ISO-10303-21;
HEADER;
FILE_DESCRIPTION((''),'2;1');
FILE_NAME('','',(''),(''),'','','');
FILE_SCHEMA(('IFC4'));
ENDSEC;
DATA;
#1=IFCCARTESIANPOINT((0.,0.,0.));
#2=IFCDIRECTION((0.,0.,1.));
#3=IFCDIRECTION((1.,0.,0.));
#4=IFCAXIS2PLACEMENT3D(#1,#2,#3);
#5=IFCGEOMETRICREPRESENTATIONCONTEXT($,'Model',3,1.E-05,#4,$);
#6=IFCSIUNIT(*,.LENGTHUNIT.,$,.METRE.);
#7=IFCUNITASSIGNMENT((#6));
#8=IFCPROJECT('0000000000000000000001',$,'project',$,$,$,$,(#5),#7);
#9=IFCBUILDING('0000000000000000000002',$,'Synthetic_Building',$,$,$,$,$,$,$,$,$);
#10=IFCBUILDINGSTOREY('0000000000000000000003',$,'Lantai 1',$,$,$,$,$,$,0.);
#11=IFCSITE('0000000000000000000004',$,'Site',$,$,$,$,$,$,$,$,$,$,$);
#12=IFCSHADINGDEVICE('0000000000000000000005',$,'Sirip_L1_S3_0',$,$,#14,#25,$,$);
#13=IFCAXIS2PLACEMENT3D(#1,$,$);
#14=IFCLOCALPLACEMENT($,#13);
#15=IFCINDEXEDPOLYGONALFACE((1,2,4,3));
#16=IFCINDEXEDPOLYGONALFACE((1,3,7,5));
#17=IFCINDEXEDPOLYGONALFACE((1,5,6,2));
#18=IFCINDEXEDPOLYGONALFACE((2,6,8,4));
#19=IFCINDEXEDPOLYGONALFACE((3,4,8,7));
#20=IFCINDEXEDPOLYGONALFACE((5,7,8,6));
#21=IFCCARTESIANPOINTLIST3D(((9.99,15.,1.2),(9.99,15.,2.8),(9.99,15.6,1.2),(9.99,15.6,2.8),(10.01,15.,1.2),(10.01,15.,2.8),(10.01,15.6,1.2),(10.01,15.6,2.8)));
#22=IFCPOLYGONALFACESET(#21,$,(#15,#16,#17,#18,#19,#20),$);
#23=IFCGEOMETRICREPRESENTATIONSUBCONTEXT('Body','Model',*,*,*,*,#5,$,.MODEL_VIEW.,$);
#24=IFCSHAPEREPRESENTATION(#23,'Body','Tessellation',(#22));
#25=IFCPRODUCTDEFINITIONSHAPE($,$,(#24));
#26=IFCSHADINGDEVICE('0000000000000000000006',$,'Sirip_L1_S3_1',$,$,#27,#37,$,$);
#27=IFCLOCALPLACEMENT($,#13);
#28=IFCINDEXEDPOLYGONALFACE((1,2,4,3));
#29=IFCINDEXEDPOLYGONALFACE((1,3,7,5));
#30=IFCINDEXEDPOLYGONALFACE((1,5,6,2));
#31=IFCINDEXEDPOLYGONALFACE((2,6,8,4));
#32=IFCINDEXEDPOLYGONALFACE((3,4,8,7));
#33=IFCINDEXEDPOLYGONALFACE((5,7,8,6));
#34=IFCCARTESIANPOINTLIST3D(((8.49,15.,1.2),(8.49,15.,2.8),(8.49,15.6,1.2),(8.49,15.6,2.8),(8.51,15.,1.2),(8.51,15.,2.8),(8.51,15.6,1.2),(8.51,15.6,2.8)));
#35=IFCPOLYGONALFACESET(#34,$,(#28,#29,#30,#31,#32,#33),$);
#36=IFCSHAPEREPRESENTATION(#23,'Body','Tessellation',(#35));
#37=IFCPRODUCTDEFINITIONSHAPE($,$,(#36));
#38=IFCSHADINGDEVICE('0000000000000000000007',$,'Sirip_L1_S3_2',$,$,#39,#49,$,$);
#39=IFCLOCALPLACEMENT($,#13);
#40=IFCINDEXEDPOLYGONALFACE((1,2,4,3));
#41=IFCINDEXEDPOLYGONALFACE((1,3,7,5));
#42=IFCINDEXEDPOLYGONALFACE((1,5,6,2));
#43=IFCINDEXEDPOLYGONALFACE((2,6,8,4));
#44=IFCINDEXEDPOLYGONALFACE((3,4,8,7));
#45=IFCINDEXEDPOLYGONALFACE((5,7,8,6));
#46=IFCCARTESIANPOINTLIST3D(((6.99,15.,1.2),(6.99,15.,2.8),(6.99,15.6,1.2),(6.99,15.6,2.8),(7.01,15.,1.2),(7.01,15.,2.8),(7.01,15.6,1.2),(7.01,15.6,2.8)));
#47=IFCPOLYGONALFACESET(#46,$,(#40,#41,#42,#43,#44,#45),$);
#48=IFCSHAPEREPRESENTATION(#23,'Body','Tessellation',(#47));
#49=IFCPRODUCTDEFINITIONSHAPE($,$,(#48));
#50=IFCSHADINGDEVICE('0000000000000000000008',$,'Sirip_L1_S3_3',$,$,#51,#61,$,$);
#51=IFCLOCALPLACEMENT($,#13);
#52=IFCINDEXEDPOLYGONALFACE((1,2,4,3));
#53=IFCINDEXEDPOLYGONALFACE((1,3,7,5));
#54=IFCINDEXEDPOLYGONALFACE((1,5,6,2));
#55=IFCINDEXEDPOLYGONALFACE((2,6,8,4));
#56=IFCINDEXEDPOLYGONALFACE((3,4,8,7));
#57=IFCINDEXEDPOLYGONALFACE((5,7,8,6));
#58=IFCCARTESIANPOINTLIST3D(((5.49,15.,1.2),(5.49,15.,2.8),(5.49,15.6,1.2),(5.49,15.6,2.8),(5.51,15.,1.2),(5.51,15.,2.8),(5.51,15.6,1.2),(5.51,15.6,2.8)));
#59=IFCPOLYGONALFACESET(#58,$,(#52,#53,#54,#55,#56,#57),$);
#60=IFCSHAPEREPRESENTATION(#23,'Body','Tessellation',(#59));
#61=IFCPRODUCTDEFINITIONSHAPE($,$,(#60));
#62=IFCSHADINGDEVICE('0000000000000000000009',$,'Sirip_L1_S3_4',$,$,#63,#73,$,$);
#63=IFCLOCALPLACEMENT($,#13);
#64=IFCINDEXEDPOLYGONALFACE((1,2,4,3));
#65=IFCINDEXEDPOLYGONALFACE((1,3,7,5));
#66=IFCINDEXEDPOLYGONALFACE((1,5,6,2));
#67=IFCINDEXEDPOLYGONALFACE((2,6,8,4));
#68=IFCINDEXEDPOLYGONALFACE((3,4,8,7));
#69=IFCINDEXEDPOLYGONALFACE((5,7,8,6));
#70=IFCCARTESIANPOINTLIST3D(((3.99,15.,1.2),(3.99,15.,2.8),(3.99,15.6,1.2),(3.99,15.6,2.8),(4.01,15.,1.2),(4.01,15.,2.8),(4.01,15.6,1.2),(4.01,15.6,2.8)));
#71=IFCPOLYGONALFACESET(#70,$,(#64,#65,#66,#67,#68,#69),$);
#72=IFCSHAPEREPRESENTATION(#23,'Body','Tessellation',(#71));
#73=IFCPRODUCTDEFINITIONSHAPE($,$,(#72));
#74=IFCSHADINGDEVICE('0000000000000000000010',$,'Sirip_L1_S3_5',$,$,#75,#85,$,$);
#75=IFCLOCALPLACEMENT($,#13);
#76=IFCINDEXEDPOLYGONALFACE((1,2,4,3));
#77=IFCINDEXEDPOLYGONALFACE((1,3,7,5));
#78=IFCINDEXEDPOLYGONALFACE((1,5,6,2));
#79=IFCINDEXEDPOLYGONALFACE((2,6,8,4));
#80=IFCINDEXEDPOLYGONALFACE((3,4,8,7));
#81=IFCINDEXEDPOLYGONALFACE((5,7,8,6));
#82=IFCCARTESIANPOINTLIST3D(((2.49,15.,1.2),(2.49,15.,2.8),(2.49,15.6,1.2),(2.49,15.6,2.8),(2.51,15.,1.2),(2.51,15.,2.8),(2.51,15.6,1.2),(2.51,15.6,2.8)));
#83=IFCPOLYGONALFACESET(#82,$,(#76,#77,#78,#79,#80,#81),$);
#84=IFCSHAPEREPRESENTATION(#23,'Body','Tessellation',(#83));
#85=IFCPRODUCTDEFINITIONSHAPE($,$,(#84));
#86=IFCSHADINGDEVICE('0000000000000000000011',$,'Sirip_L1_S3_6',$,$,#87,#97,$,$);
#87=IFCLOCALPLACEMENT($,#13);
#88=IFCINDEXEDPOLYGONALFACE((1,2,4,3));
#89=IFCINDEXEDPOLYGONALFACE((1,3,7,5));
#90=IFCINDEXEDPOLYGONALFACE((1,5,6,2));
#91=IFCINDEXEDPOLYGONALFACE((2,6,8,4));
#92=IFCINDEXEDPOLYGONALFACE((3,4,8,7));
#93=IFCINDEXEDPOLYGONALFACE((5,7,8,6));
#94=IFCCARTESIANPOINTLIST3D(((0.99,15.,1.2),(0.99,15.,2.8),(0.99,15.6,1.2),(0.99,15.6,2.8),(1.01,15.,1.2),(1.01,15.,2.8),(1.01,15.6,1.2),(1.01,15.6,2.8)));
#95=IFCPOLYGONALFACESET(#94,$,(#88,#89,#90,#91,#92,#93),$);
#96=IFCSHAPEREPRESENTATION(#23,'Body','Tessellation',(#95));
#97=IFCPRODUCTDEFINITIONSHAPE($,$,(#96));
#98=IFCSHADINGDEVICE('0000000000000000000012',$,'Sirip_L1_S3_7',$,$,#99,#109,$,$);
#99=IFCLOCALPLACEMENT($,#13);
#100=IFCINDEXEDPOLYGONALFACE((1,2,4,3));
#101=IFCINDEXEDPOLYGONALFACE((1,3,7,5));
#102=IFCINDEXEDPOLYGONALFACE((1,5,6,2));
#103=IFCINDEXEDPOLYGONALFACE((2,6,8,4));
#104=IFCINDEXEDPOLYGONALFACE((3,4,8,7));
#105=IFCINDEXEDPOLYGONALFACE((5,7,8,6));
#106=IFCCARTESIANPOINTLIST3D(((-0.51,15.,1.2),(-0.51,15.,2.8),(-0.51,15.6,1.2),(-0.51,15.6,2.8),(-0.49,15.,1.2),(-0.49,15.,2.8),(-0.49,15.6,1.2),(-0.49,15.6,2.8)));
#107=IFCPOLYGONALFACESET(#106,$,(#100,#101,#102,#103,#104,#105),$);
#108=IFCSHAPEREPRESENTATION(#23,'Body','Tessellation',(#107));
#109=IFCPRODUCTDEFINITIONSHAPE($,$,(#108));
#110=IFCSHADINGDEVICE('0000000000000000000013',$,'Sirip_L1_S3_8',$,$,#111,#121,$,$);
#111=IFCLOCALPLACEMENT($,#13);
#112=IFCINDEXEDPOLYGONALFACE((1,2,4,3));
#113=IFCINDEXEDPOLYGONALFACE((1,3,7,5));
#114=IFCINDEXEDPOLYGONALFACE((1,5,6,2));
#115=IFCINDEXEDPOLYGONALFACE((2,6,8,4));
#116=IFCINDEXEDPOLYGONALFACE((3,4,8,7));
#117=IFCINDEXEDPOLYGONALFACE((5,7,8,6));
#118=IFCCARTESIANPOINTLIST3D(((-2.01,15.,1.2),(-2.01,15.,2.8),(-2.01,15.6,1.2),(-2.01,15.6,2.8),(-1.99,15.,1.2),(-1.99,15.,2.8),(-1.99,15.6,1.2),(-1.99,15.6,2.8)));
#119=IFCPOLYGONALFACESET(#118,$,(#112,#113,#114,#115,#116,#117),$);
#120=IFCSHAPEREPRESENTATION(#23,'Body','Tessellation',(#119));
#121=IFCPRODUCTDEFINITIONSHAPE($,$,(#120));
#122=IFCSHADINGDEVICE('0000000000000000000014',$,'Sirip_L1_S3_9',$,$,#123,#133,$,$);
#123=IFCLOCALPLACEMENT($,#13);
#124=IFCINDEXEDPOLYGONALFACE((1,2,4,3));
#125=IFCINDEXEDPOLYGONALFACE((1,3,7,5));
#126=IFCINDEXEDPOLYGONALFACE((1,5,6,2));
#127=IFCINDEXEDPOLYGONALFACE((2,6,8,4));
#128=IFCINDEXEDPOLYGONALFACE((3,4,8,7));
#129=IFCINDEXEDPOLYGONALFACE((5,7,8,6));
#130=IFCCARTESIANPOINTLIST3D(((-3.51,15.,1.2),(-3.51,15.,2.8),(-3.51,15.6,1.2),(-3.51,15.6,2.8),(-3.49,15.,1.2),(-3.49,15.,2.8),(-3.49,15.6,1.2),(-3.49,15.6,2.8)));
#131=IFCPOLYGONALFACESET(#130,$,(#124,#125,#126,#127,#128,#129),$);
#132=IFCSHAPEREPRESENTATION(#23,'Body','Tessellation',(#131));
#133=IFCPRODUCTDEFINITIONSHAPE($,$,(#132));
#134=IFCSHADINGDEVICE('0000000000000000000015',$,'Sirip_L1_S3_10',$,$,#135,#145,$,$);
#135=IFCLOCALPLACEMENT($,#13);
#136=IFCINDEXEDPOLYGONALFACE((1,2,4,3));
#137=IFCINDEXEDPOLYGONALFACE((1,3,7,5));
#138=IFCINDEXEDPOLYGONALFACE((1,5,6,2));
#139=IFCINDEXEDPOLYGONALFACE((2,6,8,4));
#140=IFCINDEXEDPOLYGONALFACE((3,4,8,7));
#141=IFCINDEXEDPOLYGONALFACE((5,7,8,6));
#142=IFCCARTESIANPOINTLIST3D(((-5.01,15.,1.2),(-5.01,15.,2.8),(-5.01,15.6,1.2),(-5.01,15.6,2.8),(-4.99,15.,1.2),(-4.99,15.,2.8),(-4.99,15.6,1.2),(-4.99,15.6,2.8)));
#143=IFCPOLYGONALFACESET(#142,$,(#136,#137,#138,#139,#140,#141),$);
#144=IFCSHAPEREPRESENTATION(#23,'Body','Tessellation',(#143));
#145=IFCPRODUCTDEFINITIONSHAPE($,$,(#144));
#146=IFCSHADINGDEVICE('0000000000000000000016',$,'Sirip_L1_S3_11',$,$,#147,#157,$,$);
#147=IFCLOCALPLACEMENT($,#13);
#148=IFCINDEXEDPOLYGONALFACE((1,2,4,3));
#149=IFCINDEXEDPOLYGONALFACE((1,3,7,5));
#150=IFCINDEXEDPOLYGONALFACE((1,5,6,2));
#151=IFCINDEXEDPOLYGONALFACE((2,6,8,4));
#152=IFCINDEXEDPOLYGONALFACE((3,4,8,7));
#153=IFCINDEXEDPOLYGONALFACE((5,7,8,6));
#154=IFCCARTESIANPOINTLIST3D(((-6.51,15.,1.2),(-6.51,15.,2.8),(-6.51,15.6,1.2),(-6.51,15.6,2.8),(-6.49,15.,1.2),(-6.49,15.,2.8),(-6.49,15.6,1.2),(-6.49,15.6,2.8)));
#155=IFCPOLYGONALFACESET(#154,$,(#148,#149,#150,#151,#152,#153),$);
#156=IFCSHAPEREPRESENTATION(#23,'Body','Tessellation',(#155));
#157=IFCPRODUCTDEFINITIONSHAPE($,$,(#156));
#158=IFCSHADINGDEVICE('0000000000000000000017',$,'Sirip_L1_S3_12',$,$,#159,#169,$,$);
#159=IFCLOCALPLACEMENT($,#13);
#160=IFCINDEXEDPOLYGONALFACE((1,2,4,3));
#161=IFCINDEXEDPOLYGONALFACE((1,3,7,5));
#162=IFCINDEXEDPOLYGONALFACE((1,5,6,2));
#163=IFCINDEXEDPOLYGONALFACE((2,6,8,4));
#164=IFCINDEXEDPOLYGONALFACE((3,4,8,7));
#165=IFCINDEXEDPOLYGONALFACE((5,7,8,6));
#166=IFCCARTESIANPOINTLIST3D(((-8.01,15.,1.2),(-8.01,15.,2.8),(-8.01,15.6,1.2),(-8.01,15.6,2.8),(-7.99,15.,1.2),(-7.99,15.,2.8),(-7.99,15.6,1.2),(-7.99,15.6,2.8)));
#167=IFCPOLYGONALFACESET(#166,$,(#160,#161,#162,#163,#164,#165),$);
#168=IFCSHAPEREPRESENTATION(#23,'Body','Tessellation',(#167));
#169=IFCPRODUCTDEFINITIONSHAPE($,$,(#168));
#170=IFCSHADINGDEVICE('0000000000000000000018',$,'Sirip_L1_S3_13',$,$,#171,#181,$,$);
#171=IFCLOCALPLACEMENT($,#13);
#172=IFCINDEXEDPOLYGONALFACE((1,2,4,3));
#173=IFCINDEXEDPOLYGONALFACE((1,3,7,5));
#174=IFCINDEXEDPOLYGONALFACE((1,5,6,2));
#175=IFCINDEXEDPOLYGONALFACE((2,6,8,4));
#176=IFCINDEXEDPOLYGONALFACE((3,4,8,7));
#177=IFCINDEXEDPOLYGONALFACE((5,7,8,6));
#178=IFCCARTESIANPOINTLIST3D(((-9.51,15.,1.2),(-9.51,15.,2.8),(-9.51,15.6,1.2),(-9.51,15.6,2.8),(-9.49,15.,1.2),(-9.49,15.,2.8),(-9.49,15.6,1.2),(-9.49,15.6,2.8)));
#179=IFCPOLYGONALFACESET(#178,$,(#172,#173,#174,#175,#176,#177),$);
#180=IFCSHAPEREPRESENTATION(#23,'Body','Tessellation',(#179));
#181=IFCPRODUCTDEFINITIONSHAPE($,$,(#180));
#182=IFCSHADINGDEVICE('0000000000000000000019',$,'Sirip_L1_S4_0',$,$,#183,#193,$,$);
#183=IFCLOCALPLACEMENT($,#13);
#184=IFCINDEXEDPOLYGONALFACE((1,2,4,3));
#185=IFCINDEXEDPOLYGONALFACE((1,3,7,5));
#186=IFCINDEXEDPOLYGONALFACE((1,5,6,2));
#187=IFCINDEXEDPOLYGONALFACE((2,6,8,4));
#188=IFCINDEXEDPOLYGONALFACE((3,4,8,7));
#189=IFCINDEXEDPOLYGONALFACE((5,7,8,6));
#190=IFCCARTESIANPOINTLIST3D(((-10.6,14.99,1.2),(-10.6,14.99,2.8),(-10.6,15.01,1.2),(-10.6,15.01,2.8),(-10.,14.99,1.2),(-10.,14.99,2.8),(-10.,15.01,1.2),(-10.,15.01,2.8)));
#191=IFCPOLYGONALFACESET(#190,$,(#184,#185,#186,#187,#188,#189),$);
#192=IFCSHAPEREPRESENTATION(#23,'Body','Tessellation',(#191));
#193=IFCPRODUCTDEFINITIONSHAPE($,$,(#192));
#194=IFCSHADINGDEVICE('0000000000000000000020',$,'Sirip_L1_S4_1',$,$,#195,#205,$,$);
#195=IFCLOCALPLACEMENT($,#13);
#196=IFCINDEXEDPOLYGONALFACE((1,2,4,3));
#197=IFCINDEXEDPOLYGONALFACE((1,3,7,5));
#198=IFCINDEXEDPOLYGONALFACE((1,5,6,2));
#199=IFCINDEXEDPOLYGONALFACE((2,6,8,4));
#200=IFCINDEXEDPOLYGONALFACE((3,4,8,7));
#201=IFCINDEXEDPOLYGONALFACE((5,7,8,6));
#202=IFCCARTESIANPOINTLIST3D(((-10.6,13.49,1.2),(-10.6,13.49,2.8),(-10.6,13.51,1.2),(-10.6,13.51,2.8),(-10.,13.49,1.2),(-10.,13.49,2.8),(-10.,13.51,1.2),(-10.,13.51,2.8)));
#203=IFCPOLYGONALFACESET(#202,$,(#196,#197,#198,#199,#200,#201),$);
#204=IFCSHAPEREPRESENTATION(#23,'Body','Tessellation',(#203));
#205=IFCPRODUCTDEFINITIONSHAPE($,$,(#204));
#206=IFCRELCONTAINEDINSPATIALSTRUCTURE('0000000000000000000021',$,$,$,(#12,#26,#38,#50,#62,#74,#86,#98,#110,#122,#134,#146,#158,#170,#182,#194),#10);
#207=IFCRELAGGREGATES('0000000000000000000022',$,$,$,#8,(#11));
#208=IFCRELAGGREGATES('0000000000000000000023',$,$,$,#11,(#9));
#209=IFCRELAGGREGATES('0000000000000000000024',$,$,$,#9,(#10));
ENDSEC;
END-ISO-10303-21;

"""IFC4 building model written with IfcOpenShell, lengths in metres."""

from ifc_helpers import new_model, si_unit, frame, origin_with_axes, place, context, subcontext, project, spatial, polyline, outline, extrude, element, save


model = new_model("IFC4")

# Units and contexts
model_context = context("Model", 3, precision=1e-05, world=origin_with_axes())
body_context = subcontext(model_context, "Body", "Model", "MODEL_VIEW")
ifc_project = project(units=[si_unit("LENGTHUNIT", "METRE")], contexts=[model_context])

# Site, building, storey
site = spatial("IfcSite", under=ifc_project, Name="Site")
building = spatial("IfcBuilding", under=site, Name="Synthetic_Building")
storey = spatial("IfcBuildingStorey", under=building, Name="Lantai 1", Elevation=0.0)

# Shading devices
shading_device_1_placement = place(None, origin_with_axes())
element("IfcShadingDevice", 1, at=shading_device_1_placement, inside=storey, Name="Sirip_L1_S3_0", context=body_context, shape_type="SweptSolid", body=[
    extrude(outline(polyline([(10.01, 15.0), (9.99, 15.0), (9.99, 15.6), (10.01, 15.6), (10.01, 15.0)])), frame((0.0, 0.0, 1.2), z_axis=(0.0, 0.0, 1.0), x_axis=(1.0, 0.0, 0.0)), (0.0, 0.0, 1.0), 1.6),
])
shading_device_2_placement = place(None, origin_with_axes())
element("IfcShadingDevice", 2, at=shading_device_2_placement, inside=storey, Name="Sirip_L1_S3_1", context=body_context, shape_type="SweptSolid", body=[
    extrude(outline(polyline([(8.51, 15.0), (8.49, 15.0), (8.49, 15.6), (8.51, 15.6), (8.51, 15.0)])), frame((0.0, 0.0, 1.2), z_axis=(0.0, 0.0, 1.0), x_axis=(1.0, 0.0, 0.0)), (0.0, 0.0, 1.0), 1.6),
])
shading_device_3_placement = place(None, origin_with_axes())
element("IfcShadingDevice", 3, at=shading_device_3_placement, inside=storey, Name="Sirip_L1_S3_2", context=body_context, shape_type="SweptSolid", body=[
    extrude(outline(polyline([(7.01, 15.0), (6.99, 15.0), (6.99, 15.6), (7.01, 15.6), (7.01, 15.0)])), frame((0.0, 0.0, 1.2), z_axis=(0.0, 0.0, 1.0), x_axis=(1.0, 0.0, 0.0)), (0.0, 0.0, 1.0), 1.6),
])
shading_device_4_placement = place(None, origin_with_axes())
element("IfcShadingDevice", 4, at=shading_device_4_placement, inside=storey, Name="Sirip_L1_S3_3", context=body_context, shape_type="SweptSolid", body=[
    extrude(outline(polyline([(5.51, 15.0), (5.49, 15.0), (5.49, 15.6), (5.51, 15.6), (5.51, 15.0)])), frame((0.0, 0.0, 1.2), z_axis=(0.0, 0.0, 1.0), x_axis=(1.0, 0.0, 0.0)), (0.0, 0.0, 1.0), 1.6),
])
shading_device_5_placement = place(None, origin_with_axes())
element("IfcShadingDevice", 5, at=shading_device_5_placement, inside=storey, Name="Sirip_L1_S3_4", context=body_context, shape_type="SweptSolid", body=[
    extrude(outline(polyline([(4.01, 15.0), (3.99, 15.0), (3.99, 15.6), (4.01, 15.6), (4.01, 15.0)])), frame((0.0, 0.0, 1.2), z_axis=(0.0, 0.0, 1.0), x_axis=(1.0, 0.0, 0.0)), (0.0, 0.0, 1.0), 1.6),
])
shading_device_6_placement = place(None, origin_with_axes())
element("IfcShadingDevice", 6, at=shading_device_6_placement, inside=storey, Name="Sirip_L1_S3_5", context=body_context, shape_type="SweptSolid", body=[
    extrude(outline(polyline([(2.51, 15.0), (2.49, 15.0), (2.49, 15.6), (2.51, 15.6), (2.51, 15.0)])), frame((0.0, 0.0, 1.2), z_axis=(0.0, 0.0, 1.0), x_axis=(1.0, 0.0, 0.0)), (0.0, 0.0, 1.0), 1.6),
])
shading_device_7_placement = place(None, origin_with_axes())
element("IfcShadingDevice", 7, at=shading_device_7_placement, inside=storey, Name="Sirip_L1_S3_6", context=body_context, shape_type="SweptSolid", body=[
    extrude(outline(polyline([(1.01, 15.0), (0.99, 15.0), (0.99, 15.6), (1.01, 15.6), (1.01, 15.0)])), frame((0.0, 0.0, 1.2), z_axis=(0.0, 0.0, 1.0), x_axis=(1.0, 0.0, 0.0)), (0.0, 0.0, 1.0), 1.6),
])
shading_device_8_placement = place(None, origin_with_axes())
element("IfcShadingDevice", 8, at=shading_device_8_placement, inside=storey, Name="Sirip_L1_S3_7", context=body_context, shape_type="SweptSolid", body=[
    extrude(outline(polyline([(-0.49, 15.0), (-0.51, 15.0), (-0.51, 15.6), (-0.49, 15.6), (-0.49, 15.0)])), frame((0.0, 0.0, 1.2), z_axis=(0.0, 0.0, 1.0), x_axis=(1.0, 0.0, 0.0)), (0.0, 0.0, 1.0), 1.6),
])
shading_device_9_placement = place(None, origin_with_axes())
element("IfcShadingDevice", 9, at=shading_device_9_placement, inside=storey, Name="Sirip_L1_S3_8", context=body_context, shape_type="SweptSolid", body=[
    extrude(outline(polyline([(-1.99, 15.0), (-2.01, 15.0), (-2.01, 15.6), (-1.99, 15.6), (-1.99, 15.0)])), frame((0.0, 0.0, 1.2), z_axis=(0.0, 0.0, 1.0), x_axis=(1.0, 0.0, 0.0)), (0.0, 0.0, 1.0), 1.6),
])
shading_device_10_placement = place(None, origin_with_axes())
element("IfcShadingDevice", 10, at=shading_device_10_placement, inside=storey, Name="Sirip_L1_S3_9", context=body_context, shape_type="SweptSolid", body=[
    extrude(outline(polyline([(-3.49, 15.0), (-3.51, 15.0), (-3.51, 15.6), (-3.49, 15.6), (-3.49, 15.0)])), frame((0.0, 0.0, 1.2), z_axis=(0.0, 0.0, 1.0), x_axis=(1.0, 0.0, 0.0)), (0.0, 0.0, 1.0), 1.6),
])
shading_device_11_placement = place(None, origin_with_axes())
element("IfcShadingDevice", 11, at=shading_device_11_placement, inside=storey, Name="Sirip_L1_S3_10", context=body_context, shape_type="SweptSolid", body=[
    extrude(outline(polyline([(-4.99, 15.0), (-5.01, 15.0), (-5.01, 15.6), (-4.99, 15.6), (-4.99, 15.0)])), frame((0.0, 0.0, 1.2), z_axis=(0.0, 0.0, 1.0), x_axis=(1.0, 0.0, 0.0)), (0.0, 0.0, 1.0), 1.6),
])
shading_device_12_placement = place(None, origin_with_axes())
element("IfcShadingDevice", 12, at=shading_device_12_placement, inside=storey, Name="Sirip_L1_S3_11", context=body_context, shape_type="SweptSolid", body=[
    extrude(outline(polyline([(-6.49, 15.0), (-6.51, 15.0), (-6.51, 15.6), (-6.49, 15.6), (-6.49, 15.0)])), frame((0.0, 0.0, 1.2), z_axis=(0.0, 0.0, 1.0), x_axis=(1.0, 0.0, 0.0)), (0.0, 0.0, 1.0), 1.6),
])
shading_device_13_placement = place(None, origin_with_axes())
element("IfcShadingDevice", 13, at=shading_device_13_placement, inside=storey, Name="Sirip_L1_S3_12", context=body_context, shape_type="SweptSolid", body=[
    extrude(outline(polyline([(-7.99, 15.0), (-8.01, 15.0), (-8.01, 15.6), (-7.99, 15.6), (-7.99, 15.0)])), frame((0.0, 0.0, 1.2), z_axis=(0.0, 0.0, 1.0), x_axis=(1.0, 0.0, 0.0)), (0.0, 0.0, 1.0), 1.6),
])
shading_device_14_placement = place(None, origin_with_axes())
element("IfcShadingDevice", 14, at=shading_device_14_placement, inside=storey, Name="Sirip_L1_S3_13", context=body_context, shape_type="SweptSolid", body=[
    extrude(outline(polyline([(-9.49, 15.0), (-9.51, 15.0), (-9.51, 15.6), (-9.49, 15.6), (-9.49, 15.0)])), frame((0.0, 0.0, 1.2), z_axis=(0.0, 0.0, 1.0), x_axis=(1.0, 0.0, 0.0)), (0.0, 0.0, 1.0), 1.6),
])
shading_device_15_placement = place(None, origin_with_axes())
element("IfcShadingDevice", 15, at=shading_device_15_placement, inside=storey, Name="Sirip_L1_S4_0", context=body_context, shape_type="SweptSolid", body=[
    extrude(outline(polyline([(-10.0, 15.01), (-10.0, 14.99), (-10.6, 14.99), (-10.6, 15.01), (-10.0, 15.01)])), frame((0.0, 0.0, 1.2), z_axis=(0.0, 0.0, 1.0), x_axis=(1.0, 0.0, 0.0)), (0.0, 0.0, 1.0), 1.6),
])
shading_device_16_placement = place(None, origin_with_axes())
element("IfcShadingDevice", 16, at=shading_device_16_placement, inside=storey, Name="Sirip_L1_S4_1", context=body_context, shape_type="SweptSolid", body=[
    extrude(outline(polyline([(-10.0, 13.51), (-10.0, 13.49), (-10.6, 13.49), (-10.6, 13.51), (-10.0, 13.51)])), frame((0.0, 0.0, 1.2), z_axis=(0.0, 0.0, 1.0), x_axis=(1.0, 0.0, 0.0)), (0.0, 0.0, 1.0), 1.6),
])

save(model, "model.ifc")
